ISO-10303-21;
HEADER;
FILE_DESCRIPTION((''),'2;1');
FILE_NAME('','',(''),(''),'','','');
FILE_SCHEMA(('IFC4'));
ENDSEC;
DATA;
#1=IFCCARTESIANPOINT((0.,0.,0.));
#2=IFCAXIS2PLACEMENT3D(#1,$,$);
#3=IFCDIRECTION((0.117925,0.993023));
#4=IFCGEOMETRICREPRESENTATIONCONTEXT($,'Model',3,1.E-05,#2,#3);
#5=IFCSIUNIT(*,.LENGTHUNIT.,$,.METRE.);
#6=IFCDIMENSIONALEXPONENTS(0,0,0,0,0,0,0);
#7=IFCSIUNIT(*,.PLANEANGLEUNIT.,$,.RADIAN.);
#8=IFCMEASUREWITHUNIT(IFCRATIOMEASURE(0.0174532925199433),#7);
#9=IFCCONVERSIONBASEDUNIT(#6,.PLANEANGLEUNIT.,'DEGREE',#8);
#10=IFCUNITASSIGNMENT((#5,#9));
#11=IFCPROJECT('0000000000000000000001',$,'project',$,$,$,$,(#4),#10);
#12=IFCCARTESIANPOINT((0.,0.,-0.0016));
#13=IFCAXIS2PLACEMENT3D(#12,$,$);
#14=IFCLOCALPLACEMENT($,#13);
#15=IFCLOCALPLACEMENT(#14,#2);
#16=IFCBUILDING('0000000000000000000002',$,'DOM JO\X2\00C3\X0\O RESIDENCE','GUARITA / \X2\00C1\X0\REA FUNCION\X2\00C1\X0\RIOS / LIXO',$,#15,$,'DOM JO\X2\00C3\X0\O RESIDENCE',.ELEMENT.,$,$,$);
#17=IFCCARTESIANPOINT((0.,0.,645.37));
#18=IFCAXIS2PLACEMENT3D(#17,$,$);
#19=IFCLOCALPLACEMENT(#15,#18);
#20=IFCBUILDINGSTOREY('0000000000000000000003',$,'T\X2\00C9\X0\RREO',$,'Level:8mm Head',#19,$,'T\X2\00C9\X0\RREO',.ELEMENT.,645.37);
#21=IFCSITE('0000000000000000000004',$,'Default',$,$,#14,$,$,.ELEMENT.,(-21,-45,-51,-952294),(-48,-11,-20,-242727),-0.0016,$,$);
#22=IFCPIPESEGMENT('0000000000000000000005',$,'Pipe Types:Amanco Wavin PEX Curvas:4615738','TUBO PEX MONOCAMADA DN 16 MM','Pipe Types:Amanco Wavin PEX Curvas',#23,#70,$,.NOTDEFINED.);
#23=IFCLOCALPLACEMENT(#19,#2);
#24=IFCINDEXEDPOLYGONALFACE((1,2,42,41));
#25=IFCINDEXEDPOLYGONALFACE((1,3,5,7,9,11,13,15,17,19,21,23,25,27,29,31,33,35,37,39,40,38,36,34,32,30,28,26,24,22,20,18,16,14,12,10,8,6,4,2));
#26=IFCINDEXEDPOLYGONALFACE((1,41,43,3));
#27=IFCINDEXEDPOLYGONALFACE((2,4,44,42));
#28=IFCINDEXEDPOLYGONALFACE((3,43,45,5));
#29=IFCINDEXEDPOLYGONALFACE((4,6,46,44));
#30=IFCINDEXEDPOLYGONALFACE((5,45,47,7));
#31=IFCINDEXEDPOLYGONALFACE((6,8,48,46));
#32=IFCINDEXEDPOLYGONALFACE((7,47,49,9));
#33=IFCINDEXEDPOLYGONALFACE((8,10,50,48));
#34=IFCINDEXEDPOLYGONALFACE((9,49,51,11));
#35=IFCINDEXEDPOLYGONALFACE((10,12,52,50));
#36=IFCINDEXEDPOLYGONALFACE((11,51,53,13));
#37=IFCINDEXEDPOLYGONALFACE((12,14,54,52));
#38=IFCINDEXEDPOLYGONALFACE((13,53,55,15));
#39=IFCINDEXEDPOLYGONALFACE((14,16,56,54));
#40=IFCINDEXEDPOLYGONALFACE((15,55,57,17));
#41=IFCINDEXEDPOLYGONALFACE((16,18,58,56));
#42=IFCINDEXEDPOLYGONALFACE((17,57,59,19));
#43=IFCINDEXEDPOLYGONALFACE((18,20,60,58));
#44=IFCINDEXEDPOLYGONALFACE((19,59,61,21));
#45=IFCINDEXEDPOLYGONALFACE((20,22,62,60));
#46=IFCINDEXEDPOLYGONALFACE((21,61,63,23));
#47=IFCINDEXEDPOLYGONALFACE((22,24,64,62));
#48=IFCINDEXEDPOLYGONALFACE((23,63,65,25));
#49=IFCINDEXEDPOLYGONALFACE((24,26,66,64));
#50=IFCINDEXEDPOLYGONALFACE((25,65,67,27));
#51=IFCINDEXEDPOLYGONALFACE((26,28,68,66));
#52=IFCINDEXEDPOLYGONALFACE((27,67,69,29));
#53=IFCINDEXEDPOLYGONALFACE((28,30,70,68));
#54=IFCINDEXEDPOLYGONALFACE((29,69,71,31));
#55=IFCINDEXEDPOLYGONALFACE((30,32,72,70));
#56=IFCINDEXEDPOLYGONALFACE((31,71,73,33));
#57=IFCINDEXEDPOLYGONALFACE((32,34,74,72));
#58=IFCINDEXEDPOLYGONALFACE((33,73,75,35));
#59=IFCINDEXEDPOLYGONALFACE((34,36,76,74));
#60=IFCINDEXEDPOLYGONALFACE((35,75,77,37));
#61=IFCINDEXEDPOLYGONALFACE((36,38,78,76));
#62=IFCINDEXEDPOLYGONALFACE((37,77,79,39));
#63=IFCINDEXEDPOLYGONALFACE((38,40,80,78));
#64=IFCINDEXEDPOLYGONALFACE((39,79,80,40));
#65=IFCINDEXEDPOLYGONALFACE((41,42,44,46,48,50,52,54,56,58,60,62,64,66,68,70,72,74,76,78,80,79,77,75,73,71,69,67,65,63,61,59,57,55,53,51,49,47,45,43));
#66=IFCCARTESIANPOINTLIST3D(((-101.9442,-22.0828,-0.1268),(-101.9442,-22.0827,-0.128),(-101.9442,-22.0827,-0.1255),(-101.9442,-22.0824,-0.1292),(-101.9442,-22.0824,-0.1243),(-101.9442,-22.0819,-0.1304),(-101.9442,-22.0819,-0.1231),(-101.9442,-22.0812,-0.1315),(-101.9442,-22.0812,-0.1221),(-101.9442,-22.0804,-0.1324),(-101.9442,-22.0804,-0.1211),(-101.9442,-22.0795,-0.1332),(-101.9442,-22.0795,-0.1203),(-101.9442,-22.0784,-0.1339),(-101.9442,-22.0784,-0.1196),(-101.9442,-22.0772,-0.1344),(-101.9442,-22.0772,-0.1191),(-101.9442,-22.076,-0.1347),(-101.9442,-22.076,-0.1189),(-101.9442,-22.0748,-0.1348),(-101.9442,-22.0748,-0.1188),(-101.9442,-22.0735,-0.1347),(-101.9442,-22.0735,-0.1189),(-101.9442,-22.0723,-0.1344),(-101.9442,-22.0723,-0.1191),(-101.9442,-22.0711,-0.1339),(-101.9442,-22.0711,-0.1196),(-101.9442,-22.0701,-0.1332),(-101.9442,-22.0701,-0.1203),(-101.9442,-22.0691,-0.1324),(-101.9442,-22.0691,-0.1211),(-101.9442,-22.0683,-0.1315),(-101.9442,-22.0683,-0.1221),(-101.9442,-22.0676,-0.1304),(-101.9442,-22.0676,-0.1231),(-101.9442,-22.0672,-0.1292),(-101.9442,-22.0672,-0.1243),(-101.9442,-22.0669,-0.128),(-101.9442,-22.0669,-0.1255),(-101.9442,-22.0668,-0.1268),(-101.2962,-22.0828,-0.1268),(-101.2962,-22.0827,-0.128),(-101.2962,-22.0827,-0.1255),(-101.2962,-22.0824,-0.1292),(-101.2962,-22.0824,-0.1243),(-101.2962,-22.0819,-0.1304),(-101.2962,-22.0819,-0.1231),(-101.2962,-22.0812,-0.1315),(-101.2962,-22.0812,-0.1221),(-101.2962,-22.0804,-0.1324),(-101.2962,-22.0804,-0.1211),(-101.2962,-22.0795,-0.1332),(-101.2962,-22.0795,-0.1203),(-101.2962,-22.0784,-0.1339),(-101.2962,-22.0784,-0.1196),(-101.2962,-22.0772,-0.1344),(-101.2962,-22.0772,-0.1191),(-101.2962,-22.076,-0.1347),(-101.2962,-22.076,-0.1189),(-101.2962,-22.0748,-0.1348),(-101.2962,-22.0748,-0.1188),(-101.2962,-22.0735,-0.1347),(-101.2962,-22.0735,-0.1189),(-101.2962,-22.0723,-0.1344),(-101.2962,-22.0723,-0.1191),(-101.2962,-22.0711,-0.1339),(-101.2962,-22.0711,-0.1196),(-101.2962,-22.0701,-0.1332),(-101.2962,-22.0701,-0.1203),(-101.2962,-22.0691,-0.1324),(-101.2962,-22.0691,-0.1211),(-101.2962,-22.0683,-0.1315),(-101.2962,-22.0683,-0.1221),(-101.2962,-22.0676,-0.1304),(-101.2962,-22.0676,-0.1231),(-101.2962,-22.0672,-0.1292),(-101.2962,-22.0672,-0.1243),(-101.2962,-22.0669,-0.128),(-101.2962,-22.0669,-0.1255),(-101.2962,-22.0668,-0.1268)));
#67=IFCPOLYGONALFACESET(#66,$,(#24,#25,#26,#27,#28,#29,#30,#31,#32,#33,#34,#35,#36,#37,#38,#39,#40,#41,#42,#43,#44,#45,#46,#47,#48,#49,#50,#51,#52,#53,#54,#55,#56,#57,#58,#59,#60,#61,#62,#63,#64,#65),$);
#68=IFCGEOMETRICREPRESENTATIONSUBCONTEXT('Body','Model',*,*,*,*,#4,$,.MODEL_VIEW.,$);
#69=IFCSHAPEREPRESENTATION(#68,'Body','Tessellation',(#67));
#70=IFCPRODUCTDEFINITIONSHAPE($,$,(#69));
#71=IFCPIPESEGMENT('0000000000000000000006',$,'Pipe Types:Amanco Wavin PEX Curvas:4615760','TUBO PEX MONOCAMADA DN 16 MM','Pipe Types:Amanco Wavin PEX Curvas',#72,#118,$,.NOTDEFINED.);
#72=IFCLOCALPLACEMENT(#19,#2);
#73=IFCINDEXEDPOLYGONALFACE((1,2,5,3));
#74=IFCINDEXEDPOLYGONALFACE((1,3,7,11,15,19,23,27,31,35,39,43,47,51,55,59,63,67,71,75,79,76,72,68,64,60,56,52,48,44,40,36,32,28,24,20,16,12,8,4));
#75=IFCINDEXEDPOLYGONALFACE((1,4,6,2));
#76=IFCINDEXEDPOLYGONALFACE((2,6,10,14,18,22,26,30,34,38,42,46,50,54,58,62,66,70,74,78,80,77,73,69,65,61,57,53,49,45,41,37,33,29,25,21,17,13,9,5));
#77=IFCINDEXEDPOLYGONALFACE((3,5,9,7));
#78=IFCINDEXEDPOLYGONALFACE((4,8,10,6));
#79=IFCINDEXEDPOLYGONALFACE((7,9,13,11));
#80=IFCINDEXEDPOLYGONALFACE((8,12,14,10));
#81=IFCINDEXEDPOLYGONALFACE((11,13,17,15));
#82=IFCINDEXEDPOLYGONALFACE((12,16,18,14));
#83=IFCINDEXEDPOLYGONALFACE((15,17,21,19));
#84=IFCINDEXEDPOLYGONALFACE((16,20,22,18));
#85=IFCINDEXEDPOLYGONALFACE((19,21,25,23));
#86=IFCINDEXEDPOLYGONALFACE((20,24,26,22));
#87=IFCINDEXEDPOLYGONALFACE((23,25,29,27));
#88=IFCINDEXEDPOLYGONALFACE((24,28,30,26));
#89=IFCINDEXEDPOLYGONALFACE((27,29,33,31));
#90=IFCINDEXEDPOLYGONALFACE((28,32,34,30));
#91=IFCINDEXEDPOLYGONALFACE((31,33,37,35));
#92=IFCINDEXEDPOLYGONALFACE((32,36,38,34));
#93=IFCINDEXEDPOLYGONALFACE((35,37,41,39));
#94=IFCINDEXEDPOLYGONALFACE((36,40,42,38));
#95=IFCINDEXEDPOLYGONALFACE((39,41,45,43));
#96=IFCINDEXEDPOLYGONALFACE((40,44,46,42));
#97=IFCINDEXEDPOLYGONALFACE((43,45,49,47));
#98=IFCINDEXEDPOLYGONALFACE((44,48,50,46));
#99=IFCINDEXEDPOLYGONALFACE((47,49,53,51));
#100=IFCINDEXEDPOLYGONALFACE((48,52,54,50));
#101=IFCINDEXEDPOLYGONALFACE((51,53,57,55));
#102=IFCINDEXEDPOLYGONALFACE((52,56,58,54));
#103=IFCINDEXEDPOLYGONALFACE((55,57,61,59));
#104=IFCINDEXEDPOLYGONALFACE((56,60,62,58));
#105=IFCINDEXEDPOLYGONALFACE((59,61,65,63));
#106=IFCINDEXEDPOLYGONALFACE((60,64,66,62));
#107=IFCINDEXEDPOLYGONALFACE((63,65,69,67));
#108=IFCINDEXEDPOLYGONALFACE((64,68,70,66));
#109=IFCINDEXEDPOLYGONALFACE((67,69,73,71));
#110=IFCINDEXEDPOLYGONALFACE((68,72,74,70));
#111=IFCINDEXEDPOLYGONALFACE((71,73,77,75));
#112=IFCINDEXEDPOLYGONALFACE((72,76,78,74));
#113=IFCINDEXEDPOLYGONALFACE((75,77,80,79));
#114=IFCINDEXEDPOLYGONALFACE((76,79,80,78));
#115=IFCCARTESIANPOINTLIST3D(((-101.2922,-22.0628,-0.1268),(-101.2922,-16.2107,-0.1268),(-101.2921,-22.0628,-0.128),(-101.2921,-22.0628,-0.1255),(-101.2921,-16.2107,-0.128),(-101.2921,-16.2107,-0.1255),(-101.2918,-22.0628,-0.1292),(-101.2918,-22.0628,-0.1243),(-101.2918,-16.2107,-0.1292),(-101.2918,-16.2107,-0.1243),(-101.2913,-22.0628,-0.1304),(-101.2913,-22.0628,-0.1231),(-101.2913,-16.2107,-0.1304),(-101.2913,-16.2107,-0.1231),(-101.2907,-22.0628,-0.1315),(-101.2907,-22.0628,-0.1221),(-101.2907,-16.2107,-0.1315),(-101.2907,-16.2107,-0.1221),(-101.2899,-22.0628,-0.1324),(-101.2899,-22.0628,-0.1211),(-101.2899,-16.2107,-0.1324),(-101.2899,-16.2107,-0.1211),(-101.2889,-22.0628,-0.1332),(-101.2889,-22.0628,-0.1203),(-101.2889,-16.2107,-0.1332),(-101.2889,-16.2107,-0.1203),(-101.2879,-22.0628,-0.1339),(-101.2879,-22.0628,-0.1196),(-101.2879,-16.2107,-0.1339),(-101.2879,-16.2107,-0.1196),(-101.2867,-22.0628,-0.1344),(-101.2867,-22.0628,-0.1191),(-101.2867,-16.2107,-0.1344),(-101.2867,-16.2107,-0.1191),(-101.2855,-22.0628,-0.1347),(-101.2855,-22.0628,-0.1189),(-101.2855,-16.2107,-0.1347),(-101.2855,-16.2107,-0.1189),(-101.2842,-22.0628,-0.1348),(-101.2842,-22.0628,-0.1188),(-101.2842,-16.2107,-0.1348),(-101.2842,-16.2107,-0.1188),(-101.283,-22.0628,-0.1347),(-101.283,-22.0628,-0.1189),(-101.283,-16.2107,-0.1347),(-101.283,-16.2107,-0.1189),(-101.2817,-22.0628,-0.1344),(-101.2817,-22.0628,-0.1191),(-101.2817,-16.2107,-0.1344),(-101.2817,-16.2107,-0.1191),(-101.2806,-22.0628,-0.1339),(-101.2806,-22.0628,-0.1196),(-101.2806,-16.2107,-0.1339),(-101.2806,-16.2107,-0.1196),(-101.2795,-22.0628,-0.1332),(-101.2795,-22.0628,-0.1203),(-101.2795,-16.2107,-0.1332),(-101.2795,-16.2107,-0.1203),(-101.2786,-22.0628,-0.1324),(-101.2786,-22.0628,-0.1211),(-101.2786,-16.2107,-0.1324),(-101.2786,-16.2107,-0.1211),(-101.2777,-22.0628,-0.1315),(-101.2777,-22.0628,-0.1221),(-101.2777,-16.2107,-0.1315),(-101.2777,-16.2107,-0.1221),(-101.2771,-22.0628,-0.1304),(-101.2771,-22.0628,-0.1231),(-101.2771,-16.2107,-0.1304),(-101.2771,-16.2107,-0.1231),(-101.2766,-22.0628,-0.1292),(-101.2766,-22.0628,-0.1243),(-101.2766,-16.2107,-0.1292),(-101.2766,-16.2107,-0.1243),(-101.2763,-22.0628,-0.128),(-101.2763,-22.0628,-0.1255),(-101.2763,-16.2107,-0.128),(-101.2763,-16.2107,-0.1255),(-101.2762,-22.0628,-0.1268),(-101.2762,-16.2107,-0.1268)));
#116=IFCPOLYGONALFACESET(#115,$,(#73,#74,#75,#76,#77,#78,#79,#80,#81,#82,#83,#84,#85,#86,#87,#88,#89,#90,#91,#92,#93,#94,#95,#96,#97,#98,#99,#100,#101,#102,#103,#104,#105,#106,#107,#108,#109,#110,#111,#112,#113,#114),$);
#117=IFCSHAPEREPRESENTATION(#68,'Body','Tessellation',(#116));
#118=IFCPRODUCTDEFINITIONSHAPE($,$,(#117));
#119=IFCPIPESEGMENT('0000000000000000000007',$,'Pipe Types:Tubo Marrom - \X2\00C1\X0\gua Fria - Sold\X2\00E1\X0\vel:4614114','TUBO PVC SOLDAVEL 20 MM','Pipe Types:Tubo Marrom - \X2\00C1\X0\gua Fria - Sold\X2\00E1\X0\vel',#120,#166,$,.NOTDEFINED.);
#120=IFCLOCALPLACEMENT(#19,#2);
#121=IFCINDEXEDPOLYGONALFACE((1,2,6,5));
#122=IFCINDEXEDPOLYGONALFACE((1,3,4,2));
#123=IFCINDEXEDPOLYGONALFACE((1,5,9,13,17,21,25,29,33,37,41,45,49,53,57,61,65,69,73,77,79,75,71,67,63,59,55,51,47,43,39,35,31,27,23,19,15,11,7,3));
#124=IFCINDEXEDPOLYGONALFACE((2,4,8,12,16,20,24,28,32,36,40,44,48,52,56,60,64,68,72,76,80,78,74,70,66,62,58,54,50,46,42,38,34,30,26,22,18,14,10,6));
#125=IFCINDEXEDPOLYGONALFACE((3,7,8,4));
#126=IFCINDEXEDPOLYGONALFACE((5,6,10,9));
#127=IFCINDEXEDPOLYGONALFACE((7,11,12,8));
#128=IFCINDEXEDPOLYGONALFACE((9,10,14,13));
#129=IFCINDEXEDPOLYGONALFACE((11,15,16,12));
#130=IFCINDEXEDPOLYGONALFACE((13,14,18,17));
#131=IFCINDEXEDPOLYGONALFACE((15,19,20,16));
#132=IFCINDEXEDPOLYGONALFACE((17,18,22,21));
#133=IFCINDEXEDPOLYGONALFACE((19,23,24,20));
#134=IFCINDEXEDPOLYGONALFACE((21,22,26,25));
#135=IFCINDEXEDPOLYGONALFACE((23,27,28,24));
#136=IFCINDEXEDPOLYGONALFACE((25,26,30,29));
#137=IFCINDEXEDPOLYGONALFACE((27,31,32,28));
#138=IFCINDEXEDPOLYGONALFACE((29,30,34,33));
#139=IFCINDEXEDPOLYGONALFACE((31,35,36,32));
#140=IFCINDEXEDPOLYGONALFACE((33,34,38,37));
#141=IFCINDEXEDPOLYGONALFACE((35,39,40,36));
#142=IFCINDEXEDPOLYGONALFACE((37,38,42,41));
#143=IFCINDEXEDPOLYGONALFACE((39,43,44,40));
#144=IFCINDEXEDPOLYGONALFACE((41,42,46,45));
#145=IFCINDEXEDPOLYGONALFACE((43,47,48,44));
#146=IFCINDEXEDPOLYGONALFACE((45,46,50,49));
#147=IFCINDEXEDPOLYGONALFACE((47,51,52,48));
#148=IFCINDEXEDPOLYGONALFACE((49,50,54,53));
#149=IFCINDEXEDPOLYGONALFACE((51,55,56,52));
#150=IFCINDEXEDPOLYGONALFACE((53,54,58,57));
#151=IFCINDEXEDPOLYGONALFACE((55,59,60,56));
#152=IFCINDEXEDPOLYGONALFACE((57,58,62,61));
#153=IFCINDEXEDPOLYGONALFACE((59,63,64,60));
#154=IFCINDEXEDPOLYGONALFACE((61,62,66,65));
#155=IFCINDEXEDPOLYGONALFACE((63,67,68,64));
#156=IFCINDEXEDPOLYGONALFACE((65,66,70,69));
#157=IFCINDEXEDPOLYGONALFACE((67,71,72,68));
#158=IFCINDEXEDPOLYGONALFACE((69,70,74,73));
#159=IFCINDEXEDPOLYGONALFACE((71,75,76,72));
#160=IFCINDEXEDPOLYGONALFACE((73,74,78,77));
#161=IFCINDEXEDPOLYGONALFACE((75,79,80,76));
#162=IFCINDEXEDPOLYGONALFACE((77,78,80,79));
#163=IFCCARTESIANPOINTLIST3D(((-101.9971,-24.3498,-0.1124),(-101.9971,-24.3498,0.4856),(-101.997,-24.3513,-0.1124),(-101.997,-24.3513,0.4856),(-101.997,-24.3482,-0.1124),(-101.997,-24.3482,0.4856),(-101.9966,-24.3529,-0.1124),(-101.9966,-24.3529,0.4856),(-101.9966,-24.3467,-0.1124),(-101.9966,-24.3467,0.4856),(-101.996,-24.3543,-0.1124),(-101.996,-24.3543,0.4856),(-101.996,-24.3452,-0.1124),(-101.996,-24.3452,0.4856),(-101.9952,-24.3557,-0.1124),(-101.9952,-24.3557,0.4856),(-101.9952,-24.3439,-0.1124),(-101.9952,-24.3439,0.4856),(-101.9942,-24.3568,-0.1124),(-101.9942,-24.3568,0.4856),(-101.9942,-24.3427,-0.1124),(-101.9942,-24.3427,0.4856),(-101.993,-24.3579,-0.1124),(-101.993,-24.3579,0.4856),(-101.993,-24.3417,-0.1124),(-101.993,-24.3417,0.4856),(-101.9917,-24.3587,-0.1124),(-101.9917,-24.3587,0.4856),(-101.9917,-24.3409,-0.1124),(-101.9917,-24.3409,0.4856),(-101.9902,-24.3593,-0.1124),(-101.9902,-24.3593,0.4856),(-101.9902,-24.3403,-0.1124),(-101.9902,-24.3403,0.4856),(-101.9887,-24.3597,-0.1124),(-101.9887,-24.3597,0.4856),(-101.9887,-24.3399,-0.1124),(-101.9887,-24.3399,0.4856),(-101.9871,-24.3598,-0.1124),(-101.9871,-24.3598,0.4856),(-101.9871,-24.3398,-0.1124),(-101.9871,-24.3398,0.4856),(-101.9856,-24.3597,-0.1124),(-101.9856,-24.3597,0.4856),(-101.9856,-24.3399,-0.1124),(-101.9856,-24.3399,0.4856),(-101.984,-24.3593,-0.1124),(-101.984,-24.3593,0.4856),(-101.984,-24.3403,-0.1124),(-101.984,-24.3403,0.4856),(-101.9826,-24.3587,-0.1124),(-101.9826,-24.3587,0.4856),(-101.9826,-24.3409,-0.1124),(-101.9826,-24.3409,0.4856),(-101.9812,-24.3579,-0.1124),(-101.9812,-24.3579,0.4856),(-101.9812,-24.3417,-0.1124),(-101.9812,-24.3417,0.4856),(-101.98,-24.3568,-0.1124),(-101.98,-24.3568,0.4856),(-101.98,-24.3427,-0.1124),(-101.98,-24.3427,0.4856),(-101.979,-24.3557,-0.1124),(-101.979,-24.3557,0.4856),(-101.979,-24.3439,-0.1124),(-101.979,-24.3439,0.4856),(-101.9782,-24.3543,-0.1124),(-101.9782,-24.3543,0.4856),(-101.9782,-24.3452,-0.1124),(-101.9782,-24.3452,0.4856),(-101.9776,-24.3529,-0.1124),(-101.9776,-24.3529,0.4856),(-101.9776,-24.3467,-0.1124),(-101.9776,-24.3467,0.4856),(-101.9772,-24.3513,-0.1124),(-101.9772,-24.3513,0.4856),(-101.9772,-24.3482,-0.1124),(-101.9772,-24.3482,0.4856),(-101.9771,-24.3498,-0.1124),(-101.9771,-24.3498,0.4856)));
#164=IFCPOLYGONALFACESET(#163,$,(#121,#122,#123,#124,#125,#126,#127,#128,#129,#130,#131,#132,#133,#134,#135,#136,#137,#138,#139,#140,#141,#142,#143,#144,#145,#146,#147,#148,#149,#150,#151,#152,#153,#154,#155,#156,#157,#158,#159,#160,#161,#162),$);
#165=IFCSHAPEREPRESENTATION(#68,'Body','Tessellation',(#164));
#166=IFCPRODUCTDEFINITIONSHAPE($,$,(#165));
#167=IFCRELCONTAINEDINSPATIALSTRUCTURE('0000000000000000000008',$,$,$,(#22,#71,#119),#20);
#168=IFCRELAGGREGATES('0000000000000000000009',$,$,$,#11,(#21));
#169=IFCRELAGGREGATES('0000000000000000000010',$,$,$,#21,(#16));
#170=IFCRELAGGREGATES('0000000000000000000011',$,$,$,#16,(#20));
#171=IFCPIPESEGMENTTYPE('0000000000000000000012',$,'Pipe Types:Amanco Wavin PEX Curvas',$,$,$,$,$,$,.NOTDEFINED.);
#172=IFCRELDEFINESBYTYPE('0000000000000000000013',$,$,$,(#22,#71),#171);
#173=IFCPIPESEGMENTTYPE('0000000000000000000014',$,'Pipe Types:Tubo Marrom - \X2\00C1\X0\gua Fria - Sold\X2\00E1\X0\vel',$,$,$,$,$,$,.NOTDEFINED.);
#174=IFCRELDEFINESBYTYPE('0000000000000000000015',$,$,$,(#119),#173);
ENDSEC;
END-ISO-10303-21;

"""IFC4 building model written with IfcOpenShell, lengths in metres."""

from ifc_helpers import new_model, entity, si_unit, converted_unit, direction, frame, origin, place, context, subcontext, project, spatial, indexed_curve, outline, extrude, type_object, element, save


model = new_model("IFC4")

# Units and contexts
model_context = context("Model", 3, precision=1e-05, world=origin(), true_north=direction((0.117925, 0.993023)))
body_context = subcontext(model_context, "Body", "Model", "MODEL_VIEW")
ifc_project = project(units=[si_unit("LENGTHUNIT", "METRE"), converted_unit("PLANEANGLEUNIT", "DEGREE", entity("IfcRatioMeasure", 0.0174532925199433), si_unit("PLANEANGLEUNIT", "RADIAN"), dimensions=[0, 0, 0, 0, 0, 0, 0])], contexts=[model_context])

# Site, building, storey
site_placement = place(None, frame((0.0, 0.0, -0.0016)))
site = spatial("IfcSite", under=ifc_project, at=site_placement, Name="Default", CompositionType="ELEMENT", RefLatitude=(-21, -45, -51, -952294), RefLongitude=(-48, -11, -20, -242727), RefElevation=-0.0016)
building_placement = place(site_placement, origin())
building = spatial("IfcBuilding", under=site, at=building_placement, Name="DOM JOÃO RESIDENCE", Description="GUARITA / ÁREA FUNCIONÁRIOS / LIXO", LongName="DOM JOÃO RESIDENCE", CompositionType="ELEMENT")
storey_placement = place(building_placement, frame((0.0, 0.0, 645.37)))
storey = spatial("IfcBuildingStorey", under=building, at=storey_placement, Name="TÉRREO", ObjectType="Level:8mm Head", LongName="TÉRREO", CompositionType="ELEMENT", Elevation=645.37)

# Pipe segments
pipe_segment_type_1 = type_object("IfcPipeSegmentType", Name="Pipe Types:Amanco Wavin PEX Curvas", PredefinedType="NOTDEFINED")
pipe_segment_1_placement = place(storey_placement, frame((-101.9442, -22.0844, -0.1364)))
element("IfcPipeSegment", 1, at=pipe_segment_1_placement, inside=storey, type_object=pipe_segment_type_1, Name="Pipe Types:Amanco Wavin PEX Curvas:4615738", Description="TUBO PEX MONOCAMADA DN 16 MM", ObjectType="Pipe Types:Amanco Wavin PEX Curvas", PredefinedType="NOTDEFINED", context=body_context, shape_type="SweptSolid", body=[
    extrude(outline(indexed_curve([(0.008, 0.0), (0.0079, 0.0013), (0.0076, 0.0025), (0.0071, 0.0036), (0.0065, 0.0047), (0.0057, 0.0057), (0.0047, 0.0065), (0.0036, 0.0071), (0.0025, 0.0076), (0.0013, 0.0079), (0.0, 0.008), (-0.0013, 0.0079), (-0.0025, 0.0076), (-0.0036, 0.0071), (-0.0047, 0.0065), (-0.0057, 0.0057), (-0.0065, 0.0047), (-0.0071, 0.0036), (-0.0076, 0.0025), (-0.0079, 0.0013), (-0.008, 0.0), (-0.0079, -0.0013), (-0.0076, -0.0025), (-0.0071, -0.0036), (-0.0065, -0.0047), (-0.0057, -0.0057), (-0.0047, -0.0065), (-0.0036, -0.0071), (-0.0025, -0.0076), (-0.0013, -0.0079), (0.0, -0.008), (0.0013, -0.0079), (0.0025, -0.0076), (0.0036, -0.0071), (0.0047, -0.0065), (0.0057, -0.0057), (0.0065, -0.0047), (0.0071, -0.0036), (0.0076, -0.0025), (0.0079, -0.0013), (0.008, 0.0)], self_intersect=False)), frame((0.0, 0.0096, 0.0096), z_axis=(1.0, 0.0, 0.0), x_axis=(0.0, 1.0, 0.0)), (0.0, 0.0, 1.0), 0.648),
])
pipe_segment_2_placement = place(storey_placement, frame((-101.2938, -22.0628, -0.1364)))
element("IfcPipeSegment", 2, at=pipe_segment_2_placement, inside=storey, type_object=pipe_segment_type_1, Name="Pipe Types:Amanco Wavin PEX Curvas:4615760", Description="TUBO PEX MONOCAMADA DN 16 MM", ObjectType="Pipe Types:Amanco Wavin PEX Curvas", PredefinedType="NOTDEFINED", context=body_context, shape_type="SweptSolid", body=[
    extrude(outline(indexed_curve([(0.008, 0.0), (0.0079, 0.0013), (0.0076, 0.0025), (0.0071, 0.0036), (0.0065, 0.0047), (0.0057, 0.0057), (0.0047, 0.0065), (0.0036, 0.0071), (0.0025, 0.0076), (0.0013, 0.0079), (0.0, 0.008), (-0.0013, 0.0079), (-0.0025, 0.0076), (-0.0036, 0.0071), (-0.0047, 0.0065), (-0.0057, 0.0057), (-0.0065, 0.0047), (-0.0071, 0.0036), (-0.0076, 0.0025), (-0.0079, 0.0013), (-0.008, 0.0), (-0.0079, -0.0013), (-0.0076, -0.0025), (-0.0071, -0.0036), (-0.0065, -0.0047), (-0.0057, -0.0057), (-0.0047, -0.0065), (-0.0036, -0.0071), (-0.0025, -0.0076), (-0.0013, -0.0079), (0.0, -0.008), (0.0013, -0.0079), (0.0025, -0.0076), (0.0036, -0.0071), (0.0047, -0.0065), (0.0057, -0.0057), (0.0065, -0.0047), (0.0071, -0.0036), (0.0076, -0.0025), (0.0079, -0.0013), (0.008, 0.0)], self_intersect=False)), frame((0.0096, 0.0, 0.0096), z_axis=(0.0, 1.0, 0.0), x_axis=(-1.0, 0.0, 0.0)), (0.0, 0.0, 1.0), 5.8521),
])
pipe_segment_type_2 = type_object("IfcPipeSegmentType", Name="Pipe Types:Tubo Marrom - Água Fria - Soldável", PredefinedType="NOTDEFINED")
pipe_segment_3_placement = place(storey_placement, frame((-101.9987, -24.3614, -0.1124)))
element("IfcPipeSegment", 3, at=pipe_segment_3_placement, inside=storey, type_object=pipe_segment_type_2, Name="Pipe Types:Tubo Marrom - Água Fria - Soldável:4614114", Description="TUBO PVC SOLDAVEL 20 MM", ObjectType="Pipe Types:Tubo Marrom - Água Fria - Soldável", PredefinedType="NOTDEFINED", context=body_context, shape_type="SweptSolid", body=[
    extrude(outline(indexed_curve([(0.01, 0.0), (0.0099, 0.0016), (0.0095, 0.0031), (0.0089, 0.0045), (0.0081, 0.0059), (0.0071, 0.0071), (0.0059, 0.0081), (0.0045, 0.0089), (0.0031, 0.0095), (0.0016, 0.0099), (0.0, 0.01), (-0.0016, 0.0099), (-0.0031, 0.0095), (-0.0045, 0.0089), (-0.0059, 0.0081), (-0.0071, 0.0071), (-0.0081, 0.0059), (-0.0089, 0.0045), (-0.0095, 0.0031), (-0.0099, 0.0016), (-0.01, 0.0), (-0.0099, -0.0016), (-0.0095, -0.0031), (-0.0089, -0.0045), (-0.0081, -0.0059), (-0.0071, -0.0071), (-0.0059, -0.0081), (-0.0045, -0.0089), (-0.0031, -0.0095), (-0.0016, -0.0099), (0.0, -0.01), (0.0016, -0.0099), (0.0031, -0.0095), (0.0045, -0.0089), (0.0059, -0.0081), (0.0071, -0.0071), (0.0081, -0.0059), (0.0089, -0.0045), (0.0095, -0.0031), (0.0099, -0.0016), (0.01, 0.0)], self_intersect=False)), frame((0.0116, 0.0116, 0.0)), (0.0, 0.0, 1.0), 0.598),
])

save(model, "model.ifc")
